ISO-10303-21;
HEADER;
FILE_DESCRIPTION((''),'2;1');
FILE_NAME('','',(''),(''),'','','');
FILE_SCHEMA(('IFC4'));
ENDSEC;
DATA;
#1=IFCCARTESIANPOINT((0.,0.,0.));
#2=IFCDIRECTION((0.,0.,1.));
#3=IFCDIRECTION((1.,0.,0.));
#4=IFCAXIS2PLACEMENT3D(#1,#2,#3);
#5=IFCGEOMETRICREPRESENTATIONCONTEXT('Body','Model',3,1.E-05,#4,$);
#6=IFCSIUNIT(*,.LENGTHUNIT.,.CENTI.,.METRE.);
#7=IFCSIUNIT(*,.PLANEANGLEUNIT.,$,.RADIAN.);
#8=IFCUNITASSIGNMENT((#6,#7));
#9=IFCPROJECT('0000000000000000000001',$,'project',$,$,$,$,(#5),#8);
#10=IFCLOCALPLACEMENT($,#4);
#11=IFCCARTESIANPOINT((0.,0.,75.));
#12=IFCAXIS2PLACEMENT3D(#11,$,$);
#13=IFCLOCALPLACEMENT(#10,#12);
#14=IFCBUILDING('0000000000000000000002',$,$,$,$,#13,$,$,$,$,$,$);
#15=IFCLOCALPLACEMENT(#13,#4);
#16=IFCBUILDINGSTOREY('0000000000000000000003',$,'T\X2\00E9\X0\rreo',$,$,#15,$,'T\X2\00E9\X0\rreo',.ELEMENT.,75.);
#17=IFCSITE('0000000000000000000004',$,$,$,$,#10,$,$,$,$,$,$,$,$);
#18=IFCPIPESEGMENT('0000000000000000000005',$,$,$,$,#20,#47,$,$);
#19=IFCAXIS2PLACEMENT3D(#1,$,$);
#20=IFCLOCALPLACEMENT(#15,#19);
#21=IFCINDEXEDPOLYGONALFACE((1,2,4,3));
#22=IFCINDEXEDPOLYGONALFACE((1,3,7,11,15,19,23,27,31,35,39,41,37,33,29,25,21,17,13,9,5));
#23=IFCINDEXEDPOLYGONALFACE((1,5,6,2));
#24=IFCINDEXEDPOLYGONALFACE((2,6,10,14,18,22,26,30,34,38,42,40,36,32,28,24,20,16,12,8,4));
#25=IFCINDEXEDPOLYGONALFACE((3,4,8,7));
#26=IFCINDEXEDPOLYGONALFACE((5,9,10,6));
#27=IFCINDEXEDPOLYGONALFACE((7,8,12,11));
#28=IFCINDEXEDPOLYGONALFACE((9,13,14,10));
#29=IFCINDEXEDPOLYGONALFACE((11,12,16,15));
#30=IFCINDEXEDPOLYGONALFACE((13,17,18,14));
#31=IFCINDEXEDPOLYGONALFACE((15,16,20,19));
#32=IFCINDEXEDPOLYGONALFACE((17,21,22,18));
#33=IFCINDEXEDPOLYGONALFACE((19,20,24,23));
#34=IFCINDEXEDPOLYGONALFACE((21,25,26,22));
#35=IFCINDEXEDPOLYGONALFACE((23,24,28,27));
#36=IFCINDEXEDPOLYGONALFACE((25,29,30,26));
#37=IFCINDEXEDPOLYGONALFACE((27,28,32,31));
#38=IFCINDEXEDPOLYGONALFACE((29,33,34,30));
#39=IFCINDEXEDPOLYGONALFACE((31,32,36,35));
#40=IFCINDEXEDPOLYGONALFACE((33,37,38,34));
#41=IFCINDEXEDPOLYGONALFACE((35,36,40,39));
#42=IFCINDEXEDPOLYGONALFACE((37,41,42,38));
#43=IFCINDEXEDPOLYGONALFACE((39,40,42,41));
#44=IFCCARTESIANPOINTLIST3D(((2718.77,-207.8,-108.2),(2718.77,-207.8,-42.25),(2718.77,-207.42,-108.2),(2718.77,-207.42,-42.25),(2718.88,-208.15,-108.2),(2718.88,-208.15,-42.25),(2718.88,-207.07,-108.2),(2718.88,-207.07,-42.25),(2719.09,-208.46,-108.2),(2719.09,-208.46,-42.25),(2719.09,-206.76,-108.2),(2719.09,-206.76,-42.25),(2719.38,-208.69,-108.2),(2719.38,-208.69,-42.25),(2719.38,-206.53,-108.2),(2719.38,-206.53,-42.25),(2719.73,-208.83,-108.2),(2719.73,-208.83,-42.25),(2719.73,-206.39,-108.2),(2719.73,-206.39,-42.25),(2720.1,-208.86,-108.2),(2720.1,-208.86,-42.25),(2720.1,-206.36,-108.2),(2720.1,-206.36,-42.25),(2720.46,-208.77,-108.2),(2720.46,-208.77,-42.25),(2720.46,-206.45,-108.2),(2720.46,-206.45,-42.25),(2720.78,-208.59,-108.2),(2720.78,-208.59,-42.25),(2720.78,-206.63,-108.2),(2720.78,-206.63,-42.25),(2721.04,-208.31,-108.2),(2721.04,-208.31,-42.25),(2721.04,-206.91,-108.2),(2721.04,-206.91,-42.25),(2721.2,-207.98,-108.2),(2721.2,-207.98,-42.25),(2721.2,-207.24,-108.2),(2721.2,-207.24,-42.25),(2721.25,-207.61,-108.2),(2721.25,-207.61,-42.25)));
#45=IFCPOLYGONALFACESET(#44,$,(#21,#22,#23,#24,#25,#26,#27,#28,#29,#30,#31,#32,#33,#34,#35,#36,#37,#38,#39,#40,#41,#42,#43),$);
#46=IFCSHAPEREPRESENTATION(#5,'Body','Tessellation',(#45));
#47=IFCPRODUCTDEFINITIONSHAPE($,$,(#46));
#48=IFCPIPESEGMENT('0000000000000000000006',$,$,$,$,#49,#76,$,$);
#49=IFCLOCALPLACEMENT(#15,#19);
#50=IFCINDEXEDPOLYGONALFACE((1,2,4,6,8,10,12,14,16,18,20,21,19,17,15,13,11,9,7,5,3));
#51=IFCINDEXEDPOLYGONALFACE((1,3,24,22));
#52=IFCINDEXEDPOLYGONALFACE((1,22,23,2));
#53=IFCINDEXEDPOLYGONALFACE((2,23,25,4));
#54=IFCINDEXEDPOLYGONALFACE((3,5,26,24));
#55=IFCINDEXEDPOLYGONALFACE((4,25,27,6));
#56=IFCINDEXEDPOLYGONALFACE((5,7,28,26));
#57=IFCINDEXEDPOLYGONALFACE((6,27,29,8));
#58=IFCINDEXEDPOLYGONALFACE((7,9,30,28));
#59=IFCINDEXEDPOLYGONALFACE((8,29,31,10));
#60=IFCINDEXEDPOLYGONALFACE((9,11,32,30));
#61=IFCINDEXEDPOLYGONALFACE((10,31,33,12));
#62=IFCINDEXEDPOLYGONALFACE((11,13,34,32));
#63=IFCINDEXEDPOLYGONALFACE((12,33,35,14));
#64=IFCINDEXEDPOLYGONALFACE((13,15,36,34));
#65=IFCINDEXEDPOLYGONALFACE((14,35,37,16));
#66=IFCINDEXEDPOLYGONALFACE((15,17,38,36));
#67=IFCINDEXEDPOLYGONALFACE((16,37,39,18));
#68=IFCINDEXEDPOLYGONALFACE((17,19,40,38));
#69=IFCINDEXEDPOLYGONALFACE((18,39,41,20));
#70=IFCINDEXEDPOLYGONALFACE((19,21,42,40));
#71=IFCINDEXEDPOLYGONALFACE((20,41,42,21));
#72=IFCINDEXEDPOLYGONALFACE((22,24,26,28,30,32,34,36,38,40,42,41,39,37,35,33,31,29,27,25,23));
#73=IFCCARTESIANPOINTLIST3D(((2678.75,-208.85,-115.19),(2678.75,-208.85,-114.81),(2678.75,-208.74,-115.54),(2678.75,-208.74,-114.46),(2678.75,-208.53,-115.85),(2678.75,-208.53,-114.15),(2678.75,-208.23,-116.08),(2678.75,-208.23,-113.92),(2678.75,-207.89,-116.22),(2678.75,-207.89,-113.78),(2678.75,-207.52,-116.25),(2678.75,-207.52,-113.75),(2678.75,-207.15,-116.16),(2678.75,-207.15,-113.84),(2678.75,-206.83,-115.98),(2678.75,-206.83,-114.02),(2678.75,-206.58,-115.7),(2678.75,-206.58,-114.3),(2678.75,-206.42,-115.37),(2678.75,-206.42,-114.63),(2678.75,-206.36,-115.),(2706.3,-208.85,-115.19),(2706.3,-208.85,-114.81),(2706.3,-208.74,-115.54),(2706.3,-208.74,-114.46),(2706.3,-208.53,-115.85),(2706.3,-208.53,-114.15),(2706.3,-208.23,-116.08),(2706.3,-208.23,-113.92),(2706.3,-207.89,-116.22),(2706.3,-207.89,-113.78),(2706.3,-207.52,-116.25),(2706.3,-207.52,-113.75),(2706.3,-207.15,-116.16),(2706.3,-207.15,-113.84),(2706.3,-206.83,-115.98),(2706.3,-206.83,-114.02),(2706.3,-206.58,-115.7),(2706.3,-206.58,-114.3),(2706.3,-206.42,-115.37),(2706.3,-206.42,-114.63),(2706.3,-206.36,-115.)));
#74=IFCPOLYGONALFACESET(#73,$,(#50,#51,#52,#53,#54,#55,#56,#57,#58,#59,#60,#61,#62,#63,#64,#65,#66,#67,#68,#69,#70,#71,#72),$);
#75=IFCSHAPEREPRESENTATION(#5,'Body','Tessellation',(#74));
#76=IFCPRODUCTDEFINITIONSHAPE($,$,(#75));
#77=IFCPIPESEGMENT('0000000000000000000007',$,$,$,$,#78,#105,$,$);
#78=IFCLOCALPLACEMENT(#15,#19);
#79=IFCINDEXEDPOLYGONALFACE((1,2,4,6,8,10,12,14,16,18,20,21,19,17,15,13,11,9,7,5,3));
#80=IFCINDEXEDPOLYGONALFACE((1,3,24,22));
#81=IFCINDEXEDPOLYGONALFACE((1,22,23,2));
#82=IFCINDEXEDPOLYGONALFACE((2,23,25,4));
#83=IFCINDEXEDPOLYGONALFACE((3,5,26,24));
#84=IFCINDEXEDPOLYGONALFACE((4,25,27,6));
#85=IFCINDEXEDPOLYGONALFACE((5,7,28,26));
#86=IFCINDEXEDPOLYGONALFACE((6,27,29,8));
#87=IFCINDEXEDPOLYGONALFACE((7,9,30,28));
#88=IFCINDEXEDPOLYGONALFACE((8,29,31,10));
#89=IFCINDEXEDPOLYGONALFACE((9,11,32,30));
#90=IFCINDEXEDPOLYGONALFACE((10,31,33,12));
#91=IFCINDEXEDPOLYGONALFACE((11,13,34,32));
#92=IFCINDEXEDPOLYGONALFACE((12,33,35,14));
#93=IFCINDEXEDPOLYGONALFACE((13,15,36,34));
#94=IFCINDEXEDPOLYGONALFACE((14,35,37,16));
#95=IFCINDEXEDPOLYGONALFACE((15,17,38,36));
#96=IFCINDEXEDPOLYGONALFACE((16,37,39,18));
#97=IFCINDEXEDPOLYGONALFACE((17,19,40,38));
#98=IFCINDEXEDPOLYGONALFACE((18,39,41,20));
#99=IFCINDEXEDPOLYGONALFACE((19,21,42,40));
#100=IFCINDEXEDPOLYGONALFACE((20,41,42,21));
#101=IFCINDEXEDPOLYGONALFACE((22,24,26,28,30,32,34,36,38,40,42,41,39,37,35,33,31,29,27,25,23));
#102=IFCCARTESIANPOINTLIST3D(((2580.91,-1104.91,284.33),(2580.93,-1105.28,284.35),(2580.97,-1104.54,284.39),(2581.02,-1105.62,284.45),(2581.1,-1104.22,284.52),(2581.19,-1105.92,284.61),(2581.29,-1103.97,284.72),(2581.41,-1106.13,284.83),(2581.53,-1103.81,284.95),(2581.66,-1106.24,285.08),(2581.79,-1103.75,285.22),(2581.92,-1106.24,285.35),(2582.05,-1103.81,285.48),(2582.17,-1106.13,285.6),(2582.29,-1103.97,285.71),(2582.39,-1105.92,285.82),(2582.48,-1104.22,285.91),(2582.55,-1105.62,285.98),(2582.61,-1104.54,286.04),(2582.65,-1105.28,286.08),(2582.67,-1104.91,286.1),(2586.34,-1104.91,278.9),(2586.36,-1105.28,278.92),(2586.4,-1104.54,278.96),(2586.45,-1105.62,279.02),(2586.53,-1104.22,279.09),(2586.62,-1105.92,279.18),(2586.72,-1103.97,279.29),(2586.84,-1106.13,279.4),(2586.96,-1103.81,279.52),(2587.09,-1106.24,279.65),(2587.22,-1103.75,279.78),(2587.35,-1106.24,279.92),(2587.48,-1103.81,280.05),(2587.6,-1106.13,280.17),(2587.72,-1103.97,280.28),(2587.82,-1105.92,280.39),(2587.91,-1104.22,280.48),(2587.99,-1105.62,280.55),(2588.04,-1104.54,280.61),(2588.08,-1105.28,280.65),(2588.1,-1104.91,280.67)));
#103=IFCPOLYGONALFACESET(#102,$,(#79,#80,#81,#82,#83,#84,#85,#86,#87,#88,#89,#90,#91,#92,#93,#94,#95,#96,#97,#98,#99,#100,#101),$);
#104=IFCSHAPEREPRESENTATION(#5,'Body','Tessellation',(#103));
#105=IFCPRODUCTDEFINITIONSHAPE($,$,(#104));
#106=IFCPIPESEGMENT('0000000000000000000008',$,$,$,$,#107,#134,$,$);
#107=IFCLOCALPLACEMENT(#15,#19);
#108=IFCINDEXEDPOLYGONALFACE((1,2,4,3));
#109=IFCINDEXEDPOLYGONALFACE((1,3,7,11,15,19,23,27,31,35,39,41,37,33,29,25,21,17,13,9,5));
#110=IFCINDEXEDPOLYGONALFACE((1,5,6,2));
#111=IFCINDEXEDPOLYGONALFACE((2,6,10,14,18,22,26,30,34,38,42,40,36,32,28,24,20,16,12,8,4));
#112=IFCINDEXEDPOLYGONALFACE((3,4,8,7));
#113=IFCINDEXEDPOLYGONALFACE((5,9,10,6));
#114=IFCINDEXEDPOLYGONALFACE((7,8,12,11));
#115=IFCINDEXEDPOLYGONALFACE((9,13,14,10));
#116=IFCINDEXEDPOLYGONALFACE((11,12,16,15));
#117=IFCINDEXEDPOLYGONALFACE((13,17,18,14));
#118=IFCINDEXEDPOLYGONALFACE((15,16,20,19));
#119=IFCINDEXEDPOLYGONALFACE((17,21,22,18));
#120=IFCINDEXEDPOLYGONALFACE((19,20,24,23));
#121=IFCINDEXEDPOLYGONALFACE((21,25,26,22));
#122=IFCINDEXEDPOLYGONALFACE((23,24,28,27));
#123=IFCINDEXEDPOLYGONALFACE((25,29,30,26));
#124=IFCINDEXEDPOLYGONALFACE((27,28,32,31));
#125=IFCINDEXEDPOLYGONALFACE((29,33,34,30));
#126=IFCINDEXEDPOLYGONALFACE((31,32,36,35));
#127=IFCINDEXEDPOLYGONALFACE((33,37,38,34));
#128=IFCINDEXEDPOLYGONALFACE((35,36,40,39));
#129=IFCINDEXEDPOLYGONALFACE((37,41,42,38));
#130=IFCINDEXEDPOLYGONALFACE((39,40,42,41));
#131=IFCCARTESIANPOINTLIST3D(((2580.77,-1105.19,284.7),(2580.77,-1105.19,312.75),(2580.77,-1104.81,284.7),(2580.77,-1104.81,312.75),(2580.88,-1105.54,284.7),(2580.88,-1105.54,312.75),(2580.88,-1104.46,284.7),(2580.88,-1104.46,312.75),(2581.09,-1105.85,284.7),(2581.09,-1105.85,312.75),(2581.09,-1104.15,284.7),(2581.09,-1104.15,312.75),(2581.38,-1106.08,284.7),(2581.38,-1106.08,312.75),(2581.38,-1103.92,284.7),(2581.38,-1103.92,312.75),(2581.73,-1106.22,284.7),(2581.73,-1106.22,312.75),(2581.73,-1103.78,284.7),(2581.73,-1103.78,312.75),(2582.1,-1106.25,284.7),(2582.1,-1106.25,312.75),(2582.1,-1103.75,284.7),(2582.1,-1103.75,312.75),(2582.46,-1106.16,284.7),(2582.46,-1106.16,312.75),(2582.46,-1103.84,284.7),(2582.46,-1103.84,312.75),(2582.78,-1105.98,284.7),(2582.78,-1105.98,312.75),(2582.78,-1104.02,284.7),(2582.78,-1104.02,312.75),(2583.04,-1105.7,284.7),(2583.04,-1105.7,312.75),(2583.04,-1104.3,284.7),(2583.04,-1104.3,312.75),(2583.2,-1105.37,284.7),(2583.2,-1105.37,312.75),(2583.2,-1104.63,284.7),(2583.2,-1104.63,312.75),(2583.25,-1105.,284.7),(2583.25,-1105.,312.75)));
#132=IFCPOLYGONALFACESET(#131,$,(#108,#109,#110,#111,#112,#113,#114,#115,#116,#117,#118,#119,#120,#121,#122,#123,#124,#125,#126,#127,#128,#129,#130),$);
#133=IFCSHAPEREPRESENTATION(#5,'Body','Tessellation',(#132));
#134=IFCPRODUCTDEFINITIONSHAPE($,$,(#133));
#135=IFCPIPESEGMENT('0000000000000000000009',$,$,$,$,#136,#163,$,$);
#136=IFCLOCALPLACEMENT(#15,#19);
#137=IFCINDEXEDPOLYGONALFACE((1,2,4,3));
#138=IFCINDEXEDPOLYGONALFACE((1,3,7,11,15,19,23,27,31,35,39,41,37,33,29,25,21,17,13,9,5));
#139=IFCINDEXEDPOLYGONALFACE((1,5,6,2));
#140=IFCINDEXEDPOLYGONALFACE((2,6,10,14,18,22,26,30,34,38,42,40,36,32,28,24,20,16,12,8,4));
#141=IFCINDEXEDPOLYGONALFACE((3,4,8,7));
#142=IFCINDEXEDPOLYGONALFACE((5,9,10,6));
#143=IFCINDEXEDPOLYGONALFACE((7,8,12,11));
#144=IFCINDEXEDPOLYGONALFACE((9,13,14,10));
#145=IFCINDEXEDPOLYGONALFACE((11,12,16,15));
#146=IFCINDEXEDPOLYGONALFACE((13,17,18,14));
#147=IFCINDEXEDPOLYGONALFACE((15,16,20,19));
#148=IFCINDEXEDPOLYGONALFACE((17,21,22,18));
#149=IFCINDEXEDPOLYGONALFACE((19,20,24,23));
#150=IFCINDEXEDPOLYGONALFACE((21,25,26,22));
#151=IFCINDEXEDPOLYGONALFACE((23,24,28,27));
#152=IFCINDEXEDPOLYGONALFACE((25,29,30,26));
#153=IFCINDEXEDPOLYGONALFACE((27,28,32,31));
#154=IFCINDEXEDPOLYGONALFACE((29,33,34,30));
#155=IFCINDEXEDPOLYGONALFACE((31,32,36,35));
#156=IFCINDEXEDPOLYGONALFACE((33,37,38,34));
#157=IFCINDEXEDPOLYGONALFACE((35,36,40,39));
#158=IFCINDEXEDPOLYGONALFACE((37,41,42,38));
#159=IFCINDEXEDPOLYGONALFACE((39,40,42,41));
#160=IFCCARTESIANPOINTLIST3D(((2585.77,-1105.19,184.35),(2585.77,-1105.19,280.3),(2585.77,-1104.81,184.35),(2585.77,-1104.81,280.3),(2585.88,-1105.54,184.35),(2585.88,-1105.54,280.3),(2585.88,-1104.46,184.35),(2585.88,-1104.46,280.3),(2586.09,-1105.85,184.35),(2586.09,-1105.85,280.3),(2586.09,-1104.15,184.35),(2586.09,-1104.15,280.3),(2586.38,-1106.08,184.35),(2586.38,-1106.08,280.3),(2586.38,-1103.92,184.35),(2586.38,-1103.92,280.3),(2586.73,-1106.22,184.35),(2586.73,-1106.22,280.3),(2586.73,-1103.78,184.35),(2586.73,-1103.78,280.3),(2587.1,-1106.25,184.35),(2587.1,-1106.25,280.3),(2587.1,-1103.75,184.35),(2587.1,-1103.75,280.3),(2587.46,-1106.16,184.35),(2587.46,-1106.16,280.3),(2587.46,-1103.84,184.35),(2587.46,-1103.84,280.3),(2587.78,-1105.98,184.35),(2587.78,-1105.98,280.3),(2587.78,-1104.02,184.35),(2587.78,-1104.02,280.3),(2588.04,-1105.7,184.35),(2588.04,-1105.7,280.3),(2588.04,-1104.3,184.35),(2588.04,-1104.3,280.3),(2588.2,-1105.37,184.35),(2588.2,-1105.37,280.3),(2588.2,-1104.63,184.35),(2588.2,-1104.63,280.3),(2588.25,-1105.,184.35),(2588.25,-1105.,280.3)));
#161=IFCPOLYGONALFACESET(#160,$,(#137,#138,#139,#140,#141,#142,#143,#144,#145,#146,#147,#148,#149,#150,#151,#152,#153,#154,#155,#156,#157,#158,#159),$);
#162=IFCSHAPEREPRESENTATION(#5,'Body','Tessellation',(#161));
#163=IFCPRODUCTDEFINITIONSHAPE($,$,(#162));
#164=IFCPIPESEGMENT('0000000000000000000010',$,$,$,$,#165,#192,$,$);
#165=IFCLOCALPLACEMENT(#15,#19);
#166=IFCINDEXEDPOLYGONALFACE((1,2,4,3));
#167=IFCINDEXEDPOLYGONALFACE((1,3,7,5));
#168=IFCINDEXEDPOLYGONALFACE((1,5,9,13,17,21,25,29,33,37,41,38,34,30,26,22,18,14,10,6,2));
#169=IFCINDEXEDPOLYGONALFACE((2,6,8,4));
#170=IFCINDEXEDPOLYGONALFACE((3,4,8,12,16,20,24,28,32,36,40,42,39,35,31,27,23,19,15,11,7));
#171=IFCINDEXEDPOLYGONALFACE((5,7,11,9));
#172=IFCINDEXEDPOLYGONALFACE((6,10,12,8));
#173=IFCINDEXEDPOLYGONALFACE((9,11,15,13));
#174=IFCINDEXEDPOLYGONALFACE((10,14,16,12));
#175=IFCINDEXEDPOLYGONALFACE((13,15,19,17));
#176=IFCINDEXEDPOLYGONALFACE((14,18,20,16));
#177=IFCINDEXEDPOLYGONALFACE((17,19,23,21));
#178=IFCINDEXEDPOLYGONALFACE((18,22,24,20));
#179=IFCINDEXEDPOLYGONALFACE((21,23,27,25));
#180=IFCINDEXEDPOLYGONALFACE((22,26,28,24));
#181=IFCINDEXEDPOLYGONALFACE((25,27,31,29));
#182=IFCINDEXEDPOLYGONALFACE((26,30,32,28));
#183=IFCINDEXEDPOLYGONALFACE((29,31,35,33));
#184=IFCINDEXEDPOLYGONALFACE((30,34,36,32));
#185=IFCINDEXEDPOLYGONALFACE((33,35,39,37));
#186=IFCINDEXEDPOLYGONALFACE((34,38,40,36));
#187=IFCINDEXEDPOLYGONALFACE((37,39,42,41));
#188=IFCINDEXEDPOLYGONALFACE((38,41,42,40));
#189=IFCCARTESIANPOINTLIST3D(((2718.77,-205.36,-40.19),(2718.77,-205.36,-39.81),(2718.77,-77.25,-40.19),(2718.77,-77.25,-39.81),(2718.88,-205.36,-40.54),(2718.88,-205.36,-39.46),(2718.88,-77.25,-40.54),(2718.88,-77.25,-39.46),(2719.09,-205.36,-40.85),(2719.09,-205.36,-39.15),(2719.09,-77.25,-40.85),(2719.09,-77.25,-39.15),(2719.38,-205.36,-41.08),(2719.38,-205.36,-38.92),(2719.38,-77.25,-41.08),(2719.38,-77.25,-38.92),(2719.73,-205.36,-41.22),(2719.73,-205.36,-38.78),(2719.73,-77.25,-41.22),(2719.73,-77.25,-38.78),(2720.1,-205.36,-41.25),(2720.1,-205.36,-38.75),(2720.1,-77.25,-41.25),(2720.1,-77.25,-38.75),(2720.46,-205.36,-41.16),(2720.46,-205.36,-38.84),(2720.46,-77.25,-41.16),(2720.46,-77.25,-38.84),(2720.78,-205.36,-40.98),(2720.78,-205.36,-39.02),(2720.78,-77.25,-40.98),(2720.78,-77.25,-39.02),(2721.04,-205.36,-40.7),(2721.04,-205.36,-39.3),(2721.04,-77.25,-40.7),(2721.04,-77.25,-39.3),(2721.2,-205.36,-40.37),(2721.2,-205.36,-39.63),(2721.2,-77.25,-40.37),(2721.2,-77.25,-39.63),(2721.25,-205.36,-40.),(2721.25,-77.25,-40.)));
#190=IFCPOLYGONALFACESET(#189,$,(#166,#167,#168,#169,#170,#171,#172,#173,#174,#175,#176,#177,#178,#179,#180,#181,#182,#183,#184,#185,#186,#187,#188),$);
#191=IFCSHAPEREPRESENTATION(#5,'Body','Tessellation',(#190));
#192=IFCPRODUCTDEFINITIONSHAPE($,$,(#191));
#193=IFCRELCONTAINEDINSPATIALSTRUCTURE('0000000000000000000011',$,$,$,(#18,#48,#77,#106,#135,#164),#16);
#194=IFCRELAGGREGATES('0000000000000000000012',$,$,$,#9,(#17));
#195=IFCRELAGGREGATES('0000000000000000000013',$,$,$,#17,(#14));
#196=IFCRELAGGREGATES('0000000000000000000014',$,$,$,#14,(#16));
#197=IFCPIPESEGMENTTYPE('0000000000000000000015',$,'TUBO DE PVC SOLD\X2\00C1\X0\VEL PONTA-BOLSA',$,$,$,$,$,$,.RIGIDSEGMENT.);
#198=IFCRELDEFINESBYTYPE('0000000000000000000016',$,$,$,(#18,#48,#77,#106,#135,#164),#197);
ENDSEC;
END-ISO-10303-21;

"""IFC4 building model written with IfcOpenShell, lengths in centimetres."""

from ifc_helpers import new_model, si_unit, frame, origin_with_axes, origin_2d_with_axis, place, context, project, spatial, circle, extrude, type_object, element, save


model = new_model("IFC4")

# Units and contexts
model_context = context("Model", 3, precision=1e-05, world=origin_with_axes(), identifier="Body")
ifc_project = project(units=[si_unit("LENGTHUNIT", "METRE", prefix="CENTI"), si_unit("PLANEANGLEUNIT", "RADIAN")], contexts=[model_context])

# Site, building, storey
site_placement = place(None, origin_with_axes())
site = spatial("IfcSite", under=ifc_project, at=site_placement)
building_placement = place(site_placement, frame((0.0, 0.0, 75.0)))
building = spatial("IfcBuilding", under=site, at=building_placement)
storey_placement = place(building_placement, origin_with_axes())
storey = spatial("IfcBuildingStorey", under=building, at=storey_placement, Name="Térreo", LongName="Térreo", CompositionType="ELEMENT", Elevation=75.0)

# Pipe segments
pipe_segment_type_1 = type_object("IfcPipeSegmentType", Name="TUBO DE PVC SOLDÁVEL PONTA-BOLSA", PredefinedType="RIGIDSEGMENT")
pipe_segment_1_placement = place(storey_placement, frame((2720.0, -207.61, -42.25), z_axis=(0.0, 0.0, 1.0), x_axis=(1.0, 0.0, 0.0)))
element("IfcPipeSegment", 1, at=pipe_segment_1_placement, inside=storey, type_object=pipe_segment_type_1, context=model_context, shape_type="SolidModel", body=[
    extrude(circle(Radius=1.25, at=origin_2d_with_axis()), frame((0.0, 0.0, -65.95), z_axis=(0.0, 0.0, 1.0), x_axis=(1.0, 0.0, 0.0)), (0.0, 0.0, 1.0), 65.95),
])
pipe_segment_2_placement = place(storey_placement, frame((2692.53, -207.61, -113.76), z_axis=(0.0, 0.0, 1.0), x_axis=(1.0, 0.0, 0.0)))
element("IfcPipeSegment", 2, at=pipe_segment_2_placement, inside=storey, type_object=pipe_segment_type_1, context=model_context, shape_type="SolidModel", body=[
    extrude(circle(Radius=1.25, at=origin_2d_with_axis()), frame((-13.77, 0.0, -1.24), z_axis=(1.0, 0.0, 0.0), x_axis=(0.0, 1.0, 0.0)), (0.0, 0.0, 1.0), 27.55),
])
pipe_segment_3_placement = place(storey_placement, frame((2584.5, -1105.0, 286.1), z_axis=(0.0, 0.0, 1.0), x_axis=(1.0, 0.0, 0.0)))
element("IfcPipeSegment", 3, at=pipe_segment_3_placement, inside=storey, type_object=pipe_segment_type_1, context=model_context, shape_type="SolidModel", body=[
    extrude(circle(Radius=1.25, at=origin_2d_with_axis()), frame((-2.72, 0.0, -0.88), z_axis=(0.707107, 0.0, -0.707107), x_axis=(0.0, 1.0, 0.0)), (0.0, 0.0, 1.0), 7.68),
])
pipe_segment_4_placement = place(storey_placement, frame((2582.0, -1105.0, 312.75), z_axis=(0.0, 0.0, 1.0), x_axis=(1.0, 0.0, 0.0)))
element("IfcPipeSegment", 4, at=pipe_segment_4_placement, inside=storey, type_object=pipe_segment_type_1, context=model_context, shape_type="SolidModel", body=[
    extrude(circle(Radius=1.25, at=origin_2d_with_axis()), frame((0.0, 0.0, 0.0), z_axis=(0.0, 0.0, -1.0), x_axis=(1.0, 0.0, 0.0)), (0.0, 0.0, 1.0), 28.05),
])
pipe_segment_5_placement = place(storey_placement, frame((2587.0, -1105.0, 280.3), z_axis=(0.0, 0.0, 1.0), x_axis=(1.0, 0.0, 0.0)))
element("IfcPipeSegment", 5, at=pipe_segment_5_placement, inside=storey, type_object=pipe_segment_type_1, context=model_context, shape_type="SolidModel", body=[
    extrude(circle(Radius=1.25, at=origin_2d_with_axis()), frame((0.0, 0.0, 0.0), z_axis=(0.0, 0.0, -1.0), x_axis=(1.0, 0.0, 0.0)), (0.0, 0.0, 1.0), 95.95),
])
pipe_segment_6_placement = place(storey_placement, frame((2720.0, -141.3, -38.75), z_axis=(0.0, 0.0, 1.0), x_axis=(1.0, 0.0, 0.0)))
element("IfcPipeSegment", 6, at=pipe_segment_6_placement, inside=storey, type_object=pipe_segment_type_1, context=model_context, shape_type="SolidModel", body=[
    extrude(circle(Radius=1.25, at=origin_2d_with_axis()), frame((0.0, -64.05, -1.25), z_axis=(0.0, 1.0, 0.0), x_axis=(1.0, 0.0, 0.0)), (0.0, 0.0, 1.0), 128.11),
])

save(model, "model.ifc")
